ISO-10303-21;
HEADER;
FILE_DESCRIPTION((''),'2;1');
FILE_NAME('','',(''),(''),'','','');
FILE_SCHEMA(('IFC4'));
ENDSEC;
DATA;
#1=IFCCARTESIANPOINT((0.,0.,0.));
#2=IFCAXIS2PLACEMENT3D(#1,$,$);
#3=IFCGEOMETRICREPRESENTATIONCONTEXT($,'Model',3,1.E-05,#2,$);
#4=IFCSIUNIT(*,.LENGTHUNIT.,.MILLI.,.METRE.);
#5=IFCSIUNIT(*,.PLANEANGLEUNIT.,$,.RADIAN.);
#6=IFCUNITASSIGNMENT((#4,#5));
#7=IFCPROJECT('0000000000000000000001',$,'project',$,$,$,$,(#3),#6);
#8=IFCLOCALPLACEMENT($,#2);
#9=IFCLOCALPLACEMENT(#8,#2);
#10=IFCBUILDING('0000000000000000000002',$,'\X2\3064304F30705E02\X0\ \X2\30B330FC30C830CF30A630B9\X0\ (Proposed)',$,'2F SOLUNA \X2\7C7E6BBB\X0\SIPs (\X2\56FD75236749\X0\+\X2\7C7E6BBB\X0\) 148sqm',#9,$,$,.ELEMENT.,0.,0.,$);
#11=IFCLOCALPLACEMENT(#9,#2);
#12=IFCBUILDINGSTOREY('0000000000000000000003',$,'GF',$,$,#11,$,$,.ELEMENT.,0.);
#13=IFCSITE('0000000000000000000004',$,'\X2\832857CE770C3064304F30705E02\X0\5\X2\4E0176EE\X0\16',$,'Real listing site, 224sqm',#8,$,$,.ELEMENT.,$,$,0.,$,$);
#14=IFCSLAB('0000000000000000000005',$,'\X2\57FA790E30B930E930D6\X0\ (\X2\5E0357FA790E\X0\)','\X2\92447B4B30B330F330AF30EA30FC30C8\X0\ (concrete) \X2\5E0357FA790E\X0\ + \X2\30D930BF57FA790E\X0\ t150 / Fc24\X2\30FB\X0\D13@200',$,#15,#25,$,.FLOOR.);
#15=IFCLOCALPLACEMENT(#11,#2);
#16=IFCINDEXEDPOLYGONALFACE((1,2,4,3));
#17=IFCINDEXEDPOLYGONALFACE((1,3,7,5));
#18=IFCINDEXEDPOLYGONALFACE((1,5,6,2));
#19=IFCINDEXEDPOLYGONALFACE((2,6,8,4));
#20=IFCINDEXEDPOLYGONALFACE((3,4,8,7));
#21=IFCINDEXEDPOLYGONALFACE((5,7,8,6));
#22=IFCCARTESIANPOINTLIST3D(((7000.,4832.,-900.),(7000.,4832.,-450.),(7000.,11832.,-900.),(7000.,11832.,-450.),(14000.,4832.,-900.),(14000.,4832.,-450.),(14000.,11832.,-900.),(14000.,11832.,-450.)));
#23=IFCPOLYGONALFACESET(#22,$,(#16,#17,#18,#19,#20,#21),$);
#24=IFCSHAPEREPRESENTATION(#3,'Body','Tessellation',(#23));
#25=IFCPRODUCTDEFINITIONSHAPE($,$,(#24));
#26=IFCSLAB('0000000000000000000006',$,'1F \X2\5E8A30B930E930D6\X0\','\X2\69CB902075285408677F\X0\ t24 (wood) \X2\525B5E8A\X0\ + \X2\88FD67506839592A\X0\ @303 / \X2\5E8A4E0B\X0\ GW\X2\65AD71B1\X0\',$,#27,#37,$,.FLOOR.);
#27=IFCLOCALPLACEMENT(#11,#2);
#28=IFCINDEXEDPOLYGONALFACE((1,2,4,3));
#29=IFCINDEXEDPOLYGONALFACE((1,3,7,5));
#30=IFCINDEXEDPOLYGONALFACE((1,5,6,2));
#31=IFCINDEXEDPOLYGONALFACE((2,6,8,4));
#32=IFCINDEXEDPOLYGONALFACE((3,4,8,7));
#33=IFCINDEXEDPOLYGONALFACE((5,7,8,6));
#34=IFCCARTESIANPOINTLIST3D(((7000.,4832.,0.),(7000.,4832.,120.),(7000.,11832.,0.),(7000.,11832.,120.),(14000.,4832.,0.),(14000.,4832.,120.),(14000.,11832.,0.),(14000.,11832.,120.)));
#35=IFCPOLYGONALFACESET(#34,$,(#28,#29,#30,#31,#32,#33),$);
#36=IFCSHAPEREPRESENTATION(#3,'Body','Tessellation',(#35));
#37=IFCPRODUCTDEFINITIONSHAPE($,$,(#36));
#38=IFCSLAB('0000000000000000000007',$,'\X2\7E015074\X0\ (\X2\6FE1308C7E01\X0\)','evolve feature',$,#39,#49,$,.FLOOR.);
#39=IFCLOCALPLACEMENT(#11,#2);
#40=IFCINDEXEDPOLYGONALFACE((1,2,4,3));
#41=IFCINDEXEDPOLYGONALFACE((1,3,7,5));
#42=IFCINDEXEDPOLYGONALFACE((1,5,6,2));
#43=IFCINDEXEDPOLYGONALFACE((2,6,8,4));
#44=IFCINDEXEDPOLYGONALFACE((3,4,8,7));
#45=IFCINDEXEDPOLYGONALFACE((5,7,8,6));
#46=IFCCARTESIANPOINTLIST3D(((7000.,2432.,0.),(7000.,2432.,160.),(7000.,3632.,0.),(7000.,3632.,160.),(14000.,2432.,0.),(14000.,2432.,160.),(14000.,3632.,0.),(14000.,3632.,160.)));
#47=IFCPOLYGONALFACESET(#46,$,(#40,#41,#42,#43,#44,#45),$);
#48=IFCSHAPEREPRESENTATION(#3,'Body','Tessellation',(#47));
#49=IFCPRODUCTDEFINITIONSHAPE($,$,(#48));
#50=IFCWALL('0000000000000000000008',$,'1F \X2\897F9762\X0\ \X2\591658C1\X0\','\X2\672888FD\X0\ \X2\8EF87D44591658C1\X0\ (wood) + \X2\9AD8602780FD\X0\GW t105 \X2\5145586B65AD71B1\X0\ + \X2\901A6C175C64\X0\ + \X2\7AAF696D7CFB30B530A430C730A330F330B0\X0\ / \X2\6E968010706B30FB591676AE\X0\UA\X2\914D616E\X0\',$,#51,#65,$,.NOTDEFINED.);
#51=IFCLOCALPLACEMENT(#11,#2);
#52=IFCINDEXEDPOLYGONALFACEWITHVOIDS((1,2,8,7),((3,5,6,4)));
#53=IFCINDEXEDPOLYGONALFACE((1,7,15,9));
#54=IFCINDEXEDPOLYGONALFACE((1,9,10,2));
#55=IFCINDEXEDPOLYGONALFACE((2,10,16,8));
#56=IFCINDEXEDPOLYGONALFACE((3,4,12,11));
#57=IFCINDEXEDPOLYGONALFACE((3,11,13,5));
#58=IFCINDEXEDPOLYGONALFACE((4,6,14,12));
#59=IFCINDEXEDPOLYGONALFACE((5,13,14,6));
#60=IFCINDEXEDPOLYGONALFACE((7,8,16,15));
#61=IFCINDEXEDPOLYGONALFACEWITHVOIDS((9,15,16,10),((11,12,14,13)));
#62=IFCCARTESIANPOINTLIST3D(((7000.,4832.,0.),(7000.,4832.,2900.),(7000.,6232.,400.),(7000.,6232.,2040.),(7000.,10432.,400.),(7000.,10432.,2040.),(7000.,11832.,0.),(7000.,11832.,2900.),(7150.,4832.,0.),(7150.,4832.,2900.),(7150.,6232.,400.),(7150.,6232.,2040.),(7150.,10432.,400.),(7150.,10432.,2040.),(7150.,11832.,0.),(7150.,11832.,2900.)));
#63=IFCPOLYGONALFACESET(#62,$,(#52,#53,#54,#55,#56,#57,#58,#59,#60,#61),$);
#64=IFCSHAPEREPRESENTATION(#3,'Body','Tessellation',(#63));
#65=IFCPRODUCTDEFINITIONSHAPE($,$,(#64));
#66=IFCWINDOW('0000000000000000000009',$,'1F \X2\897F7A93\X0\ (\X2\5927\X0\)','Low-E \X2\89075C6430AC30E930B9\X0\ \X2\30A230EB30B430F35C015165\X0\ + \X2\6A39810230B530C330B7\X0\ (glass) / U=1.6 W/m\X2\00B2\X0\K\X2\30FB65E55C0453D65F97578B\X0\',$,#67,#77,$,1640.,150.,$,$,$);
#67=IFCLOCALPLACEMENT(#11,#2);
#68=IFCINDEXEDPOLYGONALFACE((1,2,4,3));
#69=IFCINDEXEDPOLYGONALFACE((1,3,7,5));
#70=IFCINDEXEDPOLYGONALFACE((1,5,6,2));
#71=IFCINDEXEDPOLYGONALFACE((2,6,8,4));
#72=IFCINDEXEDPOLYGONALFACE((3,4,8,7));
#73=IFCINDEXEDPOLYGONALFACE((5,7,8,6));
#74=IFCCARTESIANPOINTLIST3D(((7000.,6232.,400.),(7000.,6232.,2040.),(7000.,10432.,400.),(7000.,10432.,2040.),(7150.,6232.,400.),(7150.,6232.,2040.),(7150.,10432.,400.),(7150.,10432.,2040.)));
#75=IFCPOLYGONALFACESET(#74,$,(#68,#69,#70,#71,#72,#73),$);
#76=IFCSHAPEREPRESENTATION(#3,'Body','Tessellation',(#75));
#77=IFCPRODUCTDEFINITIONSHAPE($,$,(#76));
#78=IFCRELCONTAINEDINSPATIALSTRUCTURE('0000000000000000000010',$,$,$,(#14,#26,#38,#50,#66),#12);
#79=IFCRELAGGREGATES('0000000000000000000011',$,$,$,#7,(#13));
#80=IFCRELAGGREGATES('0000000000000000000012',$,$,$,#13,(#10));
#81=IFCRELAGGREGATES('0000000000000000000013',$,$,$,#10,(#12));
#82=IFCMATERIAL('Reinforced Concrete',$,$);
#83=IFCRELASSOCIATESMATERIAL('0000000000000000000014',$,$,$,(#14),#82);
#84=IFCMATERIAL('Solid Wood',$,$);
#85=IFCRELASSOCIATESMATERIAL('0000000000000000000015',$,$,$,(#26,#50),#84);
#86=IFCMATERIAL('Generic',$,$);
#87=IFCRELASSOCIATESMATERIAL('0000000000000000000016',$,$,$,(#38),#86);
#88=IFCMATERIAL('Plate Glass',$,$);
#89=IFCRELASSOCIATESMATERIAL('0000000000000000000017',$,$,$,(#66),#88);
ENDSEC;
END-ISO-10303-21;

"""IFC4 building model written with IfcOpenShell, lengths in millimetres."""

from ifc_helpers import new_model, si_unit, frame, frame_2d, origin, place, context, project, spatial, rectangle, extrude, material, element, fill, save


model = new_model("IFC4")

# Units and contexts
model_context = context("Model", 3, precision=1e-05, world=origin())
ifc_project = project(units=[si_unit("LENGTHUNIT", "METRE", prefix="MILLI"), si_unit("PLANEANGLEUNIT", "RADIAN")], contexts=[model_context])

# Site, building, storey
site_placement = place(None, origin())
site = spatial("IfcSite", under=ifc_project, at=site_placement, Name="茨城県つくば市5丁目16", ObjectType="Real listing site, 224sqm", CompositionType="ELEMENT", RefElevation=0.0)
building_placement = place(site_placement, origin())
building = spatial("IfcBuilding", under=site, at=building_placement, Name="つくば市 コートハウス (Proposed)", ObjectType="2F SOLUNA 籾殻SIPs (国産杉+籾殻) 148sqm", CompositionType="ELEMENT", ElevationOfRefHeight=0.0, ElevationOfTerrain=0.0)
storey_placement = place(building_placement, origin())
storey = spatial("IfcBuildingStorey", under=building, at=storey_placement, Name="GF", CompositionType="ELEMENT", Elevation=0.0)

# Slabs
ifc_material_1 = material(Name="Reinforced Concrete")
slab_1_placement = place(storey_placement, frame((3500.0, 2416.0, -450.0)))
element("IfcSlab", 1, at=slab_1_placement, inside=storey, material=ifc_material_1, Name="基礎スラブ (布基礎)", Description="鉄筋コンクリート (concrete) 布基礎 + ベタ基礎 t150 / Fc24・D13@200", PredefinedType="FLOOR", context=model_context, shape_type="SweptSolid", body=[
    extrude(rectangle(XDim=7000.0, YDim=7000.0, at=frame_2d((3500.0, 3500.0))), frame((3500.0, 2416.0, -450.0)), (0.0, 0.0, 1.0), 450.0),
])
ifc_material_2 = material(Name="Solid Wood")
slab_2_placement = place(storey_placement, frame((3500.0, 2416.0, 0.0)))
element("IfcSlab", 2, at=slab_2_placement, inside=storey, material=ifc_material_2, Name="1F 床スラブ", Description="構造用合板 t24 (wood) 剛床 + 製材根太 @303 / 床下 GW断熱", PredefinedType="FLOOR", context=model_context, shape_type="SweptSolid", body=[
    extrude(rectangle(XDim=7000.0, YDim=7000.0, at=frame_2d((3500.0, 3500.0))), frame((3500.0, 2416.0, 0.0)), (0.0, 0.0, 1.0), 120.0),
])
ifc_material_3 = material(Name="Generic")
slab_3_placement = place(storey_placement, frame((3500.0, 1216.0, 0.0)))
element("IfcSlab", 3, at=slab_3_placement, inside=storey, material=ifc_material_3, Name="縁側 (濡れ縁)", Description="evolve feature", PredefinedType="FLOOR", context=model_context, shape_type="SweptSolid", body=[
    extrude(rectangle(XDim=7000.0, YDim=1200.0, at=frame_2d((3500.0, 600.0))), frame((3500.0, 1216.0, 0.0)), (0.0, 0.0, 1.0), 160.0),
])

# Shared definitions
ifc_material_4 = material(Name="Plate Glass")

# Wall, opening, window
wall_1_placement = place(storey_placement, frame((3500.0, 2416.0, 0.0)))
wall_1 = element("IfcWall", 4, at=wall_1_placement, inside=storey, material=ifc_material_2, Name="1F 西面 外壁", Description="木製 軸組外壁 (wood) + 高性能GW t105 充填断熱 + 通気層 + 窯業系サイディング / 準耐火・外皮UA配慮", PredefinedType="NOTDEFINED", context=model_context, shape_type="SweptSolid", body=[
    extrude(rectangle(XDim=150.0, YDim=7000.0, at=frame_2d((75.0, 3500.0))), frame((3500.0, 2416.0, 0.0)), (0.0, 0.0, 1.0), 2900.0),
])
opening_1_placement = place(storey_placement, frame((3500.0, 3116.0, 200.0)))
opening_1 = element("IfcOpeningElement", 5, at=opening_1_placement, cuts=wall_1, PredefinedType="NOTDEFINED", context=model_context, shape_type="SweptSolid", body=[
    extrude(rectangle(XDim=150.0, YDim=4200.0, at=frame_2d((75.0, 2100.0))), frame((3500.0, 3116.0, 200.0)), (0.0, 0.0, 1.0), 1640.0),
])
window_1_placement = place(storey_placement, frame((3500.0, 3116.0, 200.0)))
window_1 = element("IfcWindow", 6, at=window_1_placement, inside=storey, material=ifc_material_4, Name="1F 西窓 (大)", Description="Low-E 複層ガラス アルゴン封入 + 樹脂サッシ (glass) / U=1.6 W/m²K・日射取得型", OverallHeight=1640.0, OverallWidth=150.0, context=model_context, shape_type="SweptSolid", body=[
    extrude(rectangle(XDim=150.0, YDim=4200.0, at=frame_2d((75.0, 2100.0))), frame((3500.0, 3116.0, 200.0)), (0.0, 0.0, 1.0), 1640.0),
])
fill(opening_1, window_1)

save(model, "model.ifc")
